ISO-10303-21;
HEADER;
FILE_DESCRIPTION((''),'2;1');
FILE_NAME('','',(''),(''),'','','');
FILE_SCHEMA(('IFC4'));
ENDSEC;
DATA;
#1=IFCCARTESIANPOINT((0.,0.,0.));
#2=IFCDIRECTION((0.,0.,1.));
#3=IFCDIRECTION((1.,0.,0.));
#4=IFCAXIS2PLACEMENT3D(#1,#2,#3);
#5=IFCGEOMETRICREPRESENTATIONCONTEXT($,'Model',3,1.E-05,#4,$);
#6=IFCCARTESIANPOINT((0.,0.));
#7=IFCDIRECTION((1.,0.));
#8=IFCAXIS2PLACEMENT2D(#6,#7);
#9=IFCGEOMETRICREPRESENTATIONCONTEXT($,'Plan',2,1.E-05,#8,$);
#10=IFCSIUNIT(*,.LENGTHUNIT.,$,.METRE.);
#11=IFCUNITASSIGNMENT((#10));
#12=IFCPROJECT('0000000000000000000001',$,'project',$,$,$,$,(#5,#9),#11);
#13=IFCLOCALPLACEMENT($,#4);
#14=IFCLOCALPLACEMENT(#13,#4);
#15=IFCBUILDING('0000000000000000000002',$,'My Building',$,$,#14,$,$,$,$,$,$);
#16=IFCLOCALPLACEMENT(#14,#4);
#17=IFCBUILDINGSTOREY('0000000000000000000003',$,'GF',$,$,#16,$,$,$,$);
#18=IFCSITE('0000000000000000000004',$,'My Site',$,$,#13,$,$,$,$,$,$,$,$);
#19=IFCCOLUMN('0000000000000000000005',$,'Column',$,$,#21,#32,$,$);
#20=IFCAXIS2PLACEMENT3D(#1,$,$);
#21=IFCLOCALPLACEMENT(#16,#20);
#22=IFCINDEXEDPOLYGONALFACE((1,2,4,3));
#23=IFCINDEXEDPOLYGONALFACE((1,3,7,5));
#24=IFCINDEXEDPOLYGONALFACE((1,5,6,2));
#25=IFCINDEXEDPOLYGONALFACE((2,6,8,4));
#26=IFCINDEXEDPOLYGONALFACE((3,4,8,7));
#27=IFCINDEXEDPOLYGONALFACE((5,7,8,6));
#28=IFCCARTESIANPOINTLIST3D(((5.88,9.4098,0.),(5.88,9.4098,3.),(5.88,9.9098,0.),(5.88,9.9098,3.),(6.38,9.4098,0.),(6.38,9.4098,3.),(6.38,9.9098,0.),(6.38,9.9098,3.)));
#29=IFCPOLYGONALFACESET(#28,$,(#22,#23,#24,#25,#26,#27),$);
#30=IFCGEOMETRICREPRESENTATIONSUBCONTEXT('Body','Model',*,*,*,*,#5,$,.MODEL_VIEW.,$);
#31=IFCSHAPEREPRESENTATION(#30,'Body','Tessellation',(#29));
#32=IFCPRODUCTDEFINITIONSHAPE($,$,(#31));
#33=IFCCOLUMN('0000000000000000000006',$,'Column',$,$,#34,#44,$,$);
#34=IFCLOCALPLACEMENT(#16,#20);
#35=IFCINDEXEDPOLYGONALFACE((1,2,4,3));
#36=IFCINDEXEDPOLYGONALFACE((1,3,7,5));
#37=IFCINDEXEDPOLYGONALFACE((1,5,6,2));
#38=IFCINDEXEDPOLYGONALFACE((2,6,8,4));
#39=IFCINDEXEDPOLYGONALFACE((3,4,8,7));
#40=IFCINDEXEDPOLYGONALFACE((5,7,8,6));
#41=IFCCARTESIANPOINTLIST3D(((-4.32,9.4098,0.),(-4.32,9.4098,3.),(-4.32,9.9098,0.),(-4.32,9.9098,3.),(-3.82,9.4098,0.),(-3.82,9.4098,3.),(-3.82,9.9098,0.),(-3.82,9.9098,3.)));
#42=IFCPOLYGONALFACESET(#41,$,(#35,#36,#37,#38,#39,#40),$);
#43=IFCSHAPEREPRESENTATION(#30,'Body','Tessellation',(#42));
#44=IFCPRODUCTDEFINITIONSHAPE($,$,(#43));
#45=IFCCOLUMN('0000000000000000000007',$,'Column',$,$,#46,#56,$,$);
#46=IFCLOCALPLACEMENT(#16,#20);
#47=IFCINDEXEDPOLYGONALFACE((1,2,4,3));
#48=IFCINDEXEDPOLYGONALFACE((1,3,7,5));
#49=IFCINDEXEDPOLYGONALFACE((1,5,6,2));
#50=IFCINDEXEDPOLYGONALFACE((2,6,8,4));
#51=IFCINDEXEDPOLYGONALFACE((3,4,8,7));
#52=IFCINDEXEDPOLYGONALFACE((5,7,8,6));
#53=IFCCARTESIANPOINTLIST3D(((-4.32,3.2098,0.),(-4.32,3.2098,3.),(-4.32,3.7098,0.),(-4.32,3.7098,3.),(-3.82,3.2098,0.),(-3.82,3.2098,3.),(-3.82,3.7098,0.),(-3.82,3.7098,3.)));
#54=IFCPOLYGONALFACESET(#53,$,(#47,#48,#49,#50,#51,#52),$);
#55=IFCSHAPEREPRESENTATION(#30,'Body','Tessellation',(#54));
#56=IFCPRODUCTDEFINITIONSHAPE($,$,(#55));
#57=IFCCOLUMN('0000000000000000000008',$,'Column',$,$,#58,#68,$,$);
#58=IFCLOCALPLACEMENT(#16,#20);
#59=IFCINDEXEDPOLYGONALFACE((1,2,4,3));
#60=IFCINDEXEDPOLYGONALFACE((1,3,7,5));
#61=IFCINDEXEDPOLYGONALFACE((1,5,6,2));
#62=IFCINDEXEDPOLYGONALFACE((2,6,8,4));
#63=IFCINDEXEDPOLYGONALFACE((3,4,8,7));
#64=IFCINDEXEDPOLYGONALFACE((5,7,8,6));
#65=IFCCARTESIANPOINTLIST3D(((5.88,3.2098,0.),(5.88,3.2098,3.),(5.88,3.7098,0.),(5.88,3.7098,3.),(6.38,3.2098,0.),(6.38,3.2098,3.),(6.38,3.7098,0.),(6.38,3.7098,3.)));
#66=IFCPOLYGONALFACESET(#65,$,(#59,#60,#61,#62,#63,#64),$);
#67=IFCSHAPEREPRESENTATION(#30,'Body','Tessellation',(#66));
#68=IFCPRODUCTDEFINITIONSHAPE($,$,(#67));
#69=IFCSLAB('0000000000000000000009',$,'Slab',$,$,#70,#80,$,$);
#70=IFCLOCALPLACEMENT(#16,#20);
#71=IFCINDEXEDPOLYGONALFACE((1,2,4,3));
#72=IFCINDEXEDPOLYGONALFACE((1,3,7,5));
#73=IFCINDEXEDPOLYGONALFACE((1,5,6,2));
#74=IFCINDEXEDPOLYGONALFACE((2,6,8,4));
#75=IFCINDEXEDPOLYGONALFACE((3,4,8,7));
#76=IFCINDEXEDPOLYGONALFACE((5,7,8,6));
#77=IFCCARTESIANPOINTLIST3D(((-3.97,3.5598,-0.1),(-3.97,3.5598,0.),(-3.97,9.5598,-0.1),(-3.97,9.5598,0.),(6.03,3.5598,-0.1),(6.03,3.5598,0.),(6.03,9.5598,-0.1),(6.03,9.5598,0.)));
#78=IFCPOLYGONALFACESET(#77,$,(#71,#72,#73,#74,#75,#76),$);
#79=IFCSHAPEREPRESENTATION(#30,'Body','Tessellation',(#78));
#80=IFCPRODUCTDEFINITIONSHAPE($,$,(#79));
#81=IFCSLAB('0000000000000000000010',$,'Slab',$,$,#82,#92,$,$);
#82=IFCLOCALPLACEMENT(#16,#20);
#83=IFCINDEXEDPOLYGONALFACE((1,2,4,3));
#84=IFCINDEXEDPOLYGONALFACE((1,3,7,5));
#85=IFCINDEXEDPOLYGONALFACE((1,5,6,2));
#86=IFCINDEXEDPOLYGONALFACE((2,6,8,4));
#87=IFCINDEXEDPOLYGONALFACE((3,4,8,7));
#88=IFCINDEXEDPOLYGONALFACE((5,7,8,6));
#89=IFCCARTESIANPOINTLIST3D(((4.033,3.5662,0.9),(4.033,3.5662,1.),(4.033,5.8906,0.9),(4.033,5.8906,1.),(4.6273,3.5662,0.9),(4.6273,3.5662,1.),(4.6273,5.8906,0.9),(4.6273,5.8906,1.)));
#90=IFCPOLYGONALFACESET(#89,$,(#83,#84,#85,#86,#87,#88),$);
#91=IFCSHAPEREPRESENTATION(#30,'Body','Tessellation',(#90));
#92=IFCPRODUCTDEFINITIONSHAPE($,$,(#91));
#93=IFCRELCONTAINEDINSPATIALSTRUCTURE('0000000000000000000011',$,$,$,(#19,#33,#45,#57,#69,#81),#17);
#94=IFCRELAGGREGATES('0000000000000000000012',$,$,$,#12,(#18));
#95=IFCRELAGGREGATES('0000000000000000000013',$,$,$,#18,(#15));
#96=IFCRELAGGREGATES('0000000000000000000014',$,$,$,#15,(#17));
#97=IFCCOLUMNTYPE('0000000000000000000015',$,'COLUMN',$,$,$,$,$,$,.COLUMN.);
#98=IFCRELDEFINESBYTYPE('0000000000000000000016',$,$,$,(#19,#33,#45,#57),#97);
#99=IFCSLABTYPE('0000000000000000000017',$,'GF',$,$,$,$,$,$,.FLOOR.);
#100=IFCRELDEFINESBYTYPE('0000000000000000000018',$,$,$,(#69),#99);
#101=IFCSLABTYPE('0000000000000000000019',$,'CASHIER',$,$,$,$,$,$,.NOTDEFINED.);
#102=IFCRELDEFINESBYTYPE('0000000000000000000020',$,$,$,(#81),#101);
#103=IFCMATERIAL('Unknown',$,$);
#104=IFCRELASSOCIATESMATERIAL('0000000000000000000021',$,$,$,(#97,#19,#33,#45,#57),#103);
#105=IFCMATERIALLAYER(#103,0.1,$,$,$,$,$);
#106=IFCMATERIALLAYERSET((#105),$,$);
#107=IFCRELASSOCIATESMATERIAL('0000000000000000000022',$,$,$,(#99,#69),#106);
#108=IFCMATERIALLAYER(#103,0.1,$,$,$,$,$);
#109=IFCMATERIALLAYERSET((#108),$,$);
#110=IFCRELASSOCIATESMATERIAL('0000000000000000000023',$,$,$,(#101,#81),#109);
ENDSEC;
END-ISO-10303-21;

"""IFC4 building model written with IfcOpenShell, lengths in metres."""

from ifc_helpers import new_model, si_unit, frame, origin_with_axes, origin_2d_with_axis, place, context, subcontext, project, spatial, indexed_curve, rectangle, outline, extrude, material, layer, layer_set, layer_usage, material_profile, profile_set, profile_usage, type_object, element, save


model = new_model("IFC4")

# Units and contexts
model_context = context("Model", 3, precision=1e-05, world=origin_with_axes())
plan_context = context("Plan", 2, precision=1e-05, world=origin_2d_with_axis())
body_context_1 = subcontext(model_context, "Body", "Model", "MODEL_VIEW")
ifc_project = project(units=[si_unit("LENGTHUNIT", "METRE")], contexts=[model_context, plan_context])

# Site, building, storey
site_placement = place(None, origin_with_axes())
site = spatial("IfcSite", under=ifc_project, at=site_placement, Name="My Site")
building_placement = place(site_placement, origin_with_axes())
building = spatial("IfcBuilding", under=site, at=building_placement, Name="My Building")
storey_placement = place(building_placement, origin_with_axes())
storey = spatial("IfcBuildingStorey", under=building, at=storey_placement, Name="GF")

# Columns
ifc_material = material(Name="Unknown")
ifc_material_profile = material_profile(ifc_material, rectangle(XDim=0.5, YDim=0.5))
ifc_profile_set = profile_set([ifc_material_profile])
ifc_profile_usage_1 = profile_usage(ifc_profile_set, cardinal=5)
column_type = type_object("IfcColumnType", Name="COLUMN", PredefinedType="COLUMN", material=ifc_profile_set)
column_1_placement = place(storey_placement, frame((6.13, 9.6598, 0.0), z_axis=(0.0, 0.0, 1.0), x_axis=(1.0, 0.0, 0.0)))
element("IfcColumn", 1, at=column_1_placement, inside=storey, type_object=column_type, material=ifc_profile_usage_1, Name="Column", context=body_context_1, shape_type="SweptSolid", body=[
    extrude(rectangle(XDim=0.5, YDim=0.5), origin_with_axes(), (0.0, 0.0, 1.0), 3.0),
])
ifc_profile_usage_2 = profile_usage(ifc_profile_set, cardinal=5)
column_2_placement = place(storey_placement, frame((-4.07, 9.6598, 0.0), z_axis=(0.0, 0.0, 1.0), x_axis=(1.0, 0.0, 0.0)))
element("IfcColumn", 2, at=column_2_placement, inside=storey, type_object=column_type, material=ifc_profile_usage_2, Name="Column", context=body_context_1, shape_type="SweptSolid", body=[
    extrude(rectangle(XDim=0.5, YDim=0.5), origin_with_axes(), (0.0, 0.0, 1.0), 3.0),
])
ifc_profile_usage_3 = profile_usage(ifc_profile_set, cardinal=5)
column_3_placement = place(storey_placement, frame((-4.07, 3.4598, 0.0), z_axis=(0.0, 0.0, 1.0), x_axis=(1.0, 0.0, 0.0)))
element("IfcColumn", 3, at=column_3_placement, inside=storey, type_object=column_type, material=ifc_profile_usage_3, Name="Column", context=body_context_1, shape_type="SweptSolid", body=[
    extrude(rectangle(XDim=0.5, YDim=0.5), origin_with_axes(), (0.0, 0.0, 1.0), 3.0),
])
ifc_profile_usage_4 = profile_usage(ifc_profile_set, cardinal=5)
column_4_placement = place(storey_placement, frame((6.13, 3.4598, 0.0), z_axis=(0.0, 0.0, 1.0), x_axis=(1.0, 0.0, 0.0)))
element("IfcColumn", 4, at=column_4_placement, inside=storey, type_object=column_type, material=ifc_profile_usage_4, Name="Column", context=body_context_1, shape_type="SweptSolid", body=[
    extrude(rectangle(XDim=0.5, YDim=0.5), origin_with_axes(), (0.0, 0.0, 1.0), 3.0),
])

# Slabs
ifc_layer_1 = layer(ifc_material, 0.1)
ifc_layer_set_1 = layer_set([ifc_layer_1])
ifc_layer_usage_1 = layer_usage(ifc_layer_set_1, "AXIS3", "POSITIVE", -0.1)
slab_type_1 = type_object("IfcSlabType", Name="GF", PredefinedType="FLOOR", material=ifc_layer_set_1)
slab_1_placement = place(storey_placement, frame((-3.97, 3.5598, 0.0), z_axis=(0.0, 0.0, 1.0), x_axis=(1.0, 0.0, 0.0)))
element("IfcSlab", 5, at=slab_1_placement, inside=storey, type_object=slab_type_1, material=ifc_layer_usage_1, Name="Slab", context=body_context_1, shape_type="SweptSolid", body=[
    extrude(outline(indexed_curve([(0.0, 0.0), (10.0, 0.0), (10.0, 6.0), (0.0, 6.0), (0.0, 0.0)])), frame((0.0, 0.0, -0.1), z_axis=(0.0, 0.0, 1.0), x_axis=(1.0, 0.0, 0.0)), (0.0, 0.0, 1.0), 0.1),
])
ifc_layer_2 = layer(ifc_material, 0.1)
ifc_layer_set_2 = layer_set([ifc_layer_2])
ifc_layer_usage_2 = layer_usage(ifc_layer_set_2, "AXIS3", "POSITIVE", -0.1)
slab_type_2 = type_object("IfcSlabType", Name="CASHIER", PredefinedType="NOTDEFINED", material=ifc_layer_set_2)
slab_2_placement = place(storey_placement, frame((4.033, 5.8906, 1.0), z_axis=(0.0, 0.0, 1.0), x_axis=(1.0, 0.0, 0.0)))
element("IfcSlab", 6, at=slab_2_placement, inside=storey, type_object=slab_type_2, material=ifc_layer_usage_2, Name="Slab", context=body_context_1, shape_type="SweptSolid", body=[
    extrude(outline(indexed_curve([(0.0, 0.0), (0.5943, 0.0), (0.5943, -2.3244), (0.0, -2.3244), (0.0, 0.0)])), frame((0.0, 0.0, -0.1), z_axis=(0.0, 0.0, 1.0), x_axis=(1.0, 0.0, 0.0)), (0.0, 0.0, 1.0), 0.1),
])

save(model, "model.ifc")
